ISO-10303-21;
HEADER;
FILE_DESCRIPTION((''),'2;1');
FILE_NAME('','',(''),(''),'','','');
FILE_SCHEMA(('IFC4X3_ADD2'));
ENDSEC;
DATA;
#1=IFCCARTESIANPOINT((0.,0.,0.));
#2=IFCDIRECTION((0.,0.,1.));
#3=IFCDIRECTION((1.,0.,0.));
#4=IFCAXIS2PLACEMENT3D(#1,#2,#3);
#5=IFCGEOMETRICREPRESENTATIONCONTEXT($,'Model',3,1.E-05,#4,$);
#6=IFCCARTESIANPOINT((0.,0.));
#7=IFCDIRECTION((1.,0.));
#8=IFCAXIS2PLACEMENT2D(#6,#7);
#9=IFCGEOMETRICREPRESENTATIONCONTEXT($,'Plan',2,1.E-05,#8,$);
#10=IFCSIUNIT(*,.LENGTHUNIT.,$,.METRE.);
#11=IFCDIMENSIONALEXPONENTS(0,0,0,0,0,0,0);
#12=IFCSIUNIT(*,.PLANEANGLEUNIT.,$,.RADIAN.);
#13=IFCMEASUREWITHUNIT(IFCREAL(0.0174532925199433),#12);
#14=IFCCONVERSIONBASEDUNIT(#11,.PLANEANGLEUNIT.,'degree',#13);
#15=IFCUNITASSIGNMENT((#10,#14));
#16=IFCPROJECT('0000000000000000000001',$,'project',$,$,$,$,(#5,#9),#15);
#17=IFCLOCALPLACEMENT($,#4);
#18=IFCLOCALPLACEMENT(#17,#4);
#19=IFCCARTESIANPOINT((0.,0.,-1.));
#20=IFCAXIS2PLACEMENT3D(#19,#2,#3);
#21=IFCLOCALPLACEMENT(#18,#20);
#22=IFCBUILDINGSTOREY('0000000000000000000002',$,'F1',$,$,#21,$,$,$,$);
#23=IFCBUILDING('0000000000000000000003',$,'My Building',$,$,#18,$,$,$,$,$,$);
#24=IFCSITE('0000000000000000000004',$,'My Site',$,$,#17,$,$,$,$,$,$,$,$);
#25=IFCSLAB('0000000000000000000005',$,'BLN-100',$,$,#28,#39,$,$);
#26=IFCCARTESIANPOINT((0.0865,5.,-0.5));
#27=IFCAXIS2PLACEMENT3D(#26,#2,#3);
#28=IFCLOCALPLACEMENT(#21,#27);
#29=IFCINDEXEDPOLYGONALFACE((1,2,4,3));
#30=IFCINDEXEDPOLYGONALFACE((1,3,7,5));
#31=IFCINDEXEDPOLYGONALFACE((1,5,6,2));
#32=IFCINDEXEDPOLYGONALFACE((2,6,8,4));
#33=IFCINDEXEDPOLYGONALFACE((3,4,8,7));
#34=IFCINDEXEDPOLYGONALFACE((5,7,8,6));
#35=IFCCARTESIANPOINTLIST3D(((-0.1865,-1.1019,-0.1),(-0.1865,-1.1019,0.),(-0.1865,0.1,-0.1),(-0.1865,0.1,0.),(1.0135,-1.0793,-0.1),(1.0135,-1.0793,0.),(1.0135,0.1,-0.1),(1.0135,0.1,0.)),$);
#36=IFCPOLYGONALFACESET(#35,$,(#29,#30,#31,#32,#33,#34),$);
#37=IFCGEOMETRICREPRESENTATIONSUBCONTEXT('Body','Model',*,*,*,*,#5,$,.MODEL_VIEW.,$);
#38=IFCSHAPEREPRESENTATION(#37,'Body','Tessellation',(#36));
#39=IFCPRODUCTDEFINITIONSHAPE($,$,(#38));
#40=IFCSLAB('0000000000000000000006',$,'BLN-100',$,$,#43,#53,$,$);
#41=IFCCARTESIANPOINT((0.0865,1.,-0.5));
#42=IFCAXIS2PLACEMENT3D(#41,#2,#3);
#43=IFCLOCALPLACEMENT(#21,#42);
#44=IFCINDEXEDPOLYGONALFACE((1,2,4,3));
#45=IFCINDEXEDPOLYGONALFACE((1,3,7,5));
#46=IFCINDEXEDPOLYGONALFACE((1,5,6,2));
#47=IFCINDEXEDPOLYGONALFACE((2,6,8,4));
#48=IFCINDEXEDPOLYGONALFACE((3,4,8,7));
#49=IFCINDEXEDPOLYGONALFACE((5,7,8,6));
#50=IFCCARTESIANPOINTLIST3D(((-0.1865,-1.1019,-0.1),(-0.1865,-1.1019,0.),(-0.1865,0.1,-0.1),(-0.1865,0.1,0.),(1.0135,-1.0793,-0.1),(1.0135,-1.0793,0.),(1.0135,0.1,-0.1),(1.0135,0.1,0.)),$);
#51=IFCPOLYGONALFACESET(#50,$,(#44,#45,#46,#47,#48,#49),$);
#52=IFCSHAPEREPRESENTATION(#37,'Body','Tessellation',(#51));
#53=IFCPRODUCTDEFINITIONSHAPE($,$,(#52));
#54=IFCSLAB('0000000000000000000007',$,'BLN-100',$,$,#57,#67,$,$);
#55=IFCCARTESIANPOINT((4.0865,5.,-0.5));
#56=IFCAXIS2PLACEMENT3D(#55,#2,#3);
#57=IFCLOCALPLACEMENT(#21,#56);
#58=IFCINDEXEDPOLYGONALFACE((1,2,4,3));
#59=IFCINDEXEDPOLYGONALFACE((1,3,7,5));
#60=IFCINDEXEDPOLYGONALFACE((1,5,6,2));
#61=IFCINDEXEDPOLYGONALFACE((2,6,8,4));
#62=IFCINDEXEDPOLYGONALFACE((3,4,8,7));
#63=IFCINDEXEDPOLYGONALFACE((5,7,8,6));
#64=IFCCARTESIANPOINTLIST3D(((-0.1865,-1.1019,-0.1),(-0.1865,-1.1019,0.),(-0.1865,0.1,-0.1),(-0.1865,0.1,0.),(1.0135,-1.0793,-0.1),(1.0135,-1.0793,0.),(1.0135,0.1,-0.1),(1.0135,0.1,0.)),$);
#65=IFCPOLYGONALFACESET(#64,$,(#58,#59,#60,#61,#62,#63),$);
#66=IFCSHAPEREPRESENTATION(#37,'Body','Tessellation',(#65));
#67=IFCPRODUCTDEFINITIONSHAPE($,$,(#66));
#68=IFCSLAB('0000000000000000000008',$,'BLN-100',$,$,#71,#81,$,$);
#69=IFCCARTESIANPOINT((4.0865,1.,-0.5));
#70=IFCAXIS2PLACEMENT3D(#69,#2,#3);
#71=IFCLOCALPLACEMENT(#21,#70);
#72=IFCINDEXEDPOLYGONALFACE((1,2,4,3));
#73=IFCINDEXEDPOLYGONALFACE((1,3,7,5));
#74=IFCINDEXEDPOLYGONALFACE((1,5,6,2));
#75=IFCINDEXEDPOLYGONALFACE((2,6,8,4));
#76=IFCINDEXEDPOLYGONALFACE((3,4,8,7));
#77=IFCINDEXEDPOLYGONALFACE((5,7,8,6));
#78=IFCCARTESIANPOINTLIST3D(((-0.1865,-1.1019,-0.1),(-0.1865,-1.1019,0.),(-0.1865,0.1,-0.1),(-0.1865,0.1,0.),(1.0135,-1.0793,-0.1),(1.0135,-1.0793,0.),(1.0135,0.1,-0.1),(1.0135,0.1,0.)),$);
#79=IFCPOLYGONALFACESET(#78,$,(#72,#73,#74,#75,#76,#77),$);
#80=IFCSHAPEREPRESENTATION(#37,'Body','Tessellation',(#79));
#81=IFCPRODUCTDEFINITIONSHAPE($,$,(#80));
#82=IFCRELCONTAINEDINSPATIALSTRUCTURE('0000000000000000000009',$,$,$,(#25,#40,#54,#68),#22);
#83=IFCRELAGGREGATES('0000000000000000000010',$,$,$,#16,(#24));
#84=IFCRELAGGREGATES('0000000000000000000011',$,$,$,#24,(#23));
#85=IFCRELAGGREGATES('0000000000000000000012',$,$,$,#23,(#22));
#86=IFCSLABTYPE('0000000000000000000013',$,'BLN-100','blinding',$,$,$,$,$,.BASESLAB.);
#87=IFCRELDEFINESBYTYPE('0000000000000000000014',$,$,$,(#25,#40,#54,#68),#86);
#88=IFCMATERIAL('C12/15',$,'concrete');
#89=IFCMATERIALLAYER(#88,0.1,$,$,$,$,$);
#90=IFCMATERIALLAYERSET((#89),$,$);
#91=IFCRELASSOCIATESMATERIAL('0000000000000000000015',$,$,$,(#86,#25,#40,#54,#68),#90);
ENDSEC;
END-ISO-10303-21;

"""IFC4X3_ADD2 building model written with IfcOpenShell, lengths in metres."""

from ifc_helpers import new_model, entity, si_unit, converted_unit, frame, origin_with_axes, origin_2d_with_axis, place, context, subcontext, project, spatial, indexed_curve, outline, extrude, material, layer, layer_set, layer_usage, type_object, element, save


model = new_model("IFC4X3_ADD2")

# Units and contexts
model_context = context("Model", 3, precision=1e-05, world=origin_with_axes())
plan_context = context("Plan", 2, precision=1e-05, world=origin_2d_with_axis())
body_context = subcontext(model_context, "Body", "Model", "MODEL_VIEW")
ifc_project = project(units=[si_unit("LENGTHUNIT", "METRE"), converted_unit("PLANEANGLEUNIT", "degree", entity("IfcReal", 0.0174532925199433), si_unit("PLANEANGLEUNIT", "RADIAN"), dimensions=[0, 0, 0, 0, 0, 0, 0])], contexts=[model_context, plan_context])

# Site, building, storey
site_placement = place(None, origin_with_axes())
site = spatial("IfcSite", under=ifc_project, at=site_placement, Name="My Site")
building_placement = place(site_placement, origin_with_axes())
building = spatial("IfcBuilding", under=site, at=building_placement, Name="My Building")
storey_placement = place(building_placement, frame((0.0, 0.0, -1.0), z_axis=(0.0, 0.0, 1.0), x_axis=(1.0, 0.0, 0.0)))
storey = spatial("IfcBuildingStorey", under=building, at=storey_placement, Name="F1")

# Slabs
ifc_material_1 = material(Name="C12/15", Category="concrete")
ifc_layer_1 = layer(ifc_material_1, 0.1)
ifc_layer_set_1 = layer_set([ifc_layer_1])
ifc_layer_usage_1 = layer_usage(ifc_layer_set_1, "AXIS3", "POSITIVE", -0.1)
slab_type_1 = type_object("IfcSlabType", Name="BLN-100", Description="blinding", PredefinedType="BASESLAB", material=ifc_layer_set_1)
slab_1_placement = place(storey_placement, frame((0.0865, 5.0, -0.5), z_axis=(0.0, 0.0, 1.0), x_axis=(1.0, 0.0, 0.0)))
element("IfcSlab", 1, at=slab_1_placement, inside=storey, type_object=slab_type_1, material=ifc_layer_usage_1, Name="BLN-100", context=body_context, shape_type="SweptSolid", body=[
    extrude(outline(indexed_curve([(-0.1865, -1.1019), (1.0135, -1.0793), (1.0135, 0.1), (-0.1865, 0.1), (-0.1865, -1.1019)])), frame((0.0, 0.0, -0.1), z_axis=(0.0, 0.0, 1.0), x_axis=(1.0, 0.0, 0.0)), (0.0, 0.0, 1.0), 0.1),
])
ifc_layer_usage_2 = layer_usage(ifc_layer_set_1, "AXIS3", "POSITIVE", -0.1)
slab_2_placement = place(storey_placement, frame((0.0865, 1.0, -0.5), z_axis=(0.0, 0.0, 1.0), x_axis=(1.0, 0.0, 0.0)))
element("IfcSlab", 2, at=slab_2_placement, inside=storey, type_object=slab_type_1, material=ifc_layer_usage_2, Name="BLN-100", context=body_context, shape_type="SweptSolid", body=[
    extrude(outline(indexed_curve([(-0.1865, -1.1019), (1.0135, -1.0793), (1.0135, 0.1), (-0.1865, 0.1), (-0.1865, -1.1019)])), frame((0.0, 0.0, -0.1), z_axis=(0.0, 0.0, 1.0), x_axis=(1.0, 0.0, 0.0)), (0.0, 0.0, 1.0), 0.1),
])
ifc_layer_usage_3 = layer_usage(ifc_layer_set_1, "AXIS3", "POSITIVE", -0.1)
slab_3_placement = place(storey_placement, frame((4.0865, 5.0, -0.5), z_axis=(0.0, 0.0, 1.0), x_axis=(1.0, 0.0, 0.0)))
element("IfcSlab", 3, at=slab_3_placement, inside=storey, type_object=slab_type_1, material=ifc_layer_usage_3, Name="BLN-100", context=body_context, shape_type="SweptSolid", body=[
    extrude(outline(indexed_curve([(-0.1865, -1.1019), (1.0135, -1.0793), (1.0135, 0.1), (-0.1865, 0.1), (-0.1865, -1.1019)])), frame((0.0, 0.0, -0.1), z_axis=(0.0, 0.0, 1.0), x_axis=(1.0, 0.0, 0.0)), (0.0, 0.0, 1.0), 0.1),
])
ifc_layer_usage_4 = layer_usage(ifc_layer_set_1, "AXIS3", "POSITIVE", -0.1)
slab_4_placement = place(storey_placement, frame((4.0865, 1.0, -0.5), z_axis=(0.0, 0.0, 1.0), x_axis=(1.0, 0.0, 0.0)))
element("IfcSlab", 4, at=slab_4_placement, inside=storey, type_object=slab_type_1, material=ifc_layer_usage_4, Name="BLN-100", context=body_context, shape_type="SweptSolid", body=[
    extrude(outline(indexed_curve([(-0.1865, -1.1019), (1.0135, -1.0793), (1.0135, 0.1), (-0.1865, 0.1), (-0.1865, -1.1019)])), frame((0.0, 0.0, -0.1), z_axis=(0.0, 0.0, 1.0), x_axis=(1.0, 0.0, 0.0)), (0.0, 0.0, 1.0), 0.1),
])

save(model, "model.ifc")
